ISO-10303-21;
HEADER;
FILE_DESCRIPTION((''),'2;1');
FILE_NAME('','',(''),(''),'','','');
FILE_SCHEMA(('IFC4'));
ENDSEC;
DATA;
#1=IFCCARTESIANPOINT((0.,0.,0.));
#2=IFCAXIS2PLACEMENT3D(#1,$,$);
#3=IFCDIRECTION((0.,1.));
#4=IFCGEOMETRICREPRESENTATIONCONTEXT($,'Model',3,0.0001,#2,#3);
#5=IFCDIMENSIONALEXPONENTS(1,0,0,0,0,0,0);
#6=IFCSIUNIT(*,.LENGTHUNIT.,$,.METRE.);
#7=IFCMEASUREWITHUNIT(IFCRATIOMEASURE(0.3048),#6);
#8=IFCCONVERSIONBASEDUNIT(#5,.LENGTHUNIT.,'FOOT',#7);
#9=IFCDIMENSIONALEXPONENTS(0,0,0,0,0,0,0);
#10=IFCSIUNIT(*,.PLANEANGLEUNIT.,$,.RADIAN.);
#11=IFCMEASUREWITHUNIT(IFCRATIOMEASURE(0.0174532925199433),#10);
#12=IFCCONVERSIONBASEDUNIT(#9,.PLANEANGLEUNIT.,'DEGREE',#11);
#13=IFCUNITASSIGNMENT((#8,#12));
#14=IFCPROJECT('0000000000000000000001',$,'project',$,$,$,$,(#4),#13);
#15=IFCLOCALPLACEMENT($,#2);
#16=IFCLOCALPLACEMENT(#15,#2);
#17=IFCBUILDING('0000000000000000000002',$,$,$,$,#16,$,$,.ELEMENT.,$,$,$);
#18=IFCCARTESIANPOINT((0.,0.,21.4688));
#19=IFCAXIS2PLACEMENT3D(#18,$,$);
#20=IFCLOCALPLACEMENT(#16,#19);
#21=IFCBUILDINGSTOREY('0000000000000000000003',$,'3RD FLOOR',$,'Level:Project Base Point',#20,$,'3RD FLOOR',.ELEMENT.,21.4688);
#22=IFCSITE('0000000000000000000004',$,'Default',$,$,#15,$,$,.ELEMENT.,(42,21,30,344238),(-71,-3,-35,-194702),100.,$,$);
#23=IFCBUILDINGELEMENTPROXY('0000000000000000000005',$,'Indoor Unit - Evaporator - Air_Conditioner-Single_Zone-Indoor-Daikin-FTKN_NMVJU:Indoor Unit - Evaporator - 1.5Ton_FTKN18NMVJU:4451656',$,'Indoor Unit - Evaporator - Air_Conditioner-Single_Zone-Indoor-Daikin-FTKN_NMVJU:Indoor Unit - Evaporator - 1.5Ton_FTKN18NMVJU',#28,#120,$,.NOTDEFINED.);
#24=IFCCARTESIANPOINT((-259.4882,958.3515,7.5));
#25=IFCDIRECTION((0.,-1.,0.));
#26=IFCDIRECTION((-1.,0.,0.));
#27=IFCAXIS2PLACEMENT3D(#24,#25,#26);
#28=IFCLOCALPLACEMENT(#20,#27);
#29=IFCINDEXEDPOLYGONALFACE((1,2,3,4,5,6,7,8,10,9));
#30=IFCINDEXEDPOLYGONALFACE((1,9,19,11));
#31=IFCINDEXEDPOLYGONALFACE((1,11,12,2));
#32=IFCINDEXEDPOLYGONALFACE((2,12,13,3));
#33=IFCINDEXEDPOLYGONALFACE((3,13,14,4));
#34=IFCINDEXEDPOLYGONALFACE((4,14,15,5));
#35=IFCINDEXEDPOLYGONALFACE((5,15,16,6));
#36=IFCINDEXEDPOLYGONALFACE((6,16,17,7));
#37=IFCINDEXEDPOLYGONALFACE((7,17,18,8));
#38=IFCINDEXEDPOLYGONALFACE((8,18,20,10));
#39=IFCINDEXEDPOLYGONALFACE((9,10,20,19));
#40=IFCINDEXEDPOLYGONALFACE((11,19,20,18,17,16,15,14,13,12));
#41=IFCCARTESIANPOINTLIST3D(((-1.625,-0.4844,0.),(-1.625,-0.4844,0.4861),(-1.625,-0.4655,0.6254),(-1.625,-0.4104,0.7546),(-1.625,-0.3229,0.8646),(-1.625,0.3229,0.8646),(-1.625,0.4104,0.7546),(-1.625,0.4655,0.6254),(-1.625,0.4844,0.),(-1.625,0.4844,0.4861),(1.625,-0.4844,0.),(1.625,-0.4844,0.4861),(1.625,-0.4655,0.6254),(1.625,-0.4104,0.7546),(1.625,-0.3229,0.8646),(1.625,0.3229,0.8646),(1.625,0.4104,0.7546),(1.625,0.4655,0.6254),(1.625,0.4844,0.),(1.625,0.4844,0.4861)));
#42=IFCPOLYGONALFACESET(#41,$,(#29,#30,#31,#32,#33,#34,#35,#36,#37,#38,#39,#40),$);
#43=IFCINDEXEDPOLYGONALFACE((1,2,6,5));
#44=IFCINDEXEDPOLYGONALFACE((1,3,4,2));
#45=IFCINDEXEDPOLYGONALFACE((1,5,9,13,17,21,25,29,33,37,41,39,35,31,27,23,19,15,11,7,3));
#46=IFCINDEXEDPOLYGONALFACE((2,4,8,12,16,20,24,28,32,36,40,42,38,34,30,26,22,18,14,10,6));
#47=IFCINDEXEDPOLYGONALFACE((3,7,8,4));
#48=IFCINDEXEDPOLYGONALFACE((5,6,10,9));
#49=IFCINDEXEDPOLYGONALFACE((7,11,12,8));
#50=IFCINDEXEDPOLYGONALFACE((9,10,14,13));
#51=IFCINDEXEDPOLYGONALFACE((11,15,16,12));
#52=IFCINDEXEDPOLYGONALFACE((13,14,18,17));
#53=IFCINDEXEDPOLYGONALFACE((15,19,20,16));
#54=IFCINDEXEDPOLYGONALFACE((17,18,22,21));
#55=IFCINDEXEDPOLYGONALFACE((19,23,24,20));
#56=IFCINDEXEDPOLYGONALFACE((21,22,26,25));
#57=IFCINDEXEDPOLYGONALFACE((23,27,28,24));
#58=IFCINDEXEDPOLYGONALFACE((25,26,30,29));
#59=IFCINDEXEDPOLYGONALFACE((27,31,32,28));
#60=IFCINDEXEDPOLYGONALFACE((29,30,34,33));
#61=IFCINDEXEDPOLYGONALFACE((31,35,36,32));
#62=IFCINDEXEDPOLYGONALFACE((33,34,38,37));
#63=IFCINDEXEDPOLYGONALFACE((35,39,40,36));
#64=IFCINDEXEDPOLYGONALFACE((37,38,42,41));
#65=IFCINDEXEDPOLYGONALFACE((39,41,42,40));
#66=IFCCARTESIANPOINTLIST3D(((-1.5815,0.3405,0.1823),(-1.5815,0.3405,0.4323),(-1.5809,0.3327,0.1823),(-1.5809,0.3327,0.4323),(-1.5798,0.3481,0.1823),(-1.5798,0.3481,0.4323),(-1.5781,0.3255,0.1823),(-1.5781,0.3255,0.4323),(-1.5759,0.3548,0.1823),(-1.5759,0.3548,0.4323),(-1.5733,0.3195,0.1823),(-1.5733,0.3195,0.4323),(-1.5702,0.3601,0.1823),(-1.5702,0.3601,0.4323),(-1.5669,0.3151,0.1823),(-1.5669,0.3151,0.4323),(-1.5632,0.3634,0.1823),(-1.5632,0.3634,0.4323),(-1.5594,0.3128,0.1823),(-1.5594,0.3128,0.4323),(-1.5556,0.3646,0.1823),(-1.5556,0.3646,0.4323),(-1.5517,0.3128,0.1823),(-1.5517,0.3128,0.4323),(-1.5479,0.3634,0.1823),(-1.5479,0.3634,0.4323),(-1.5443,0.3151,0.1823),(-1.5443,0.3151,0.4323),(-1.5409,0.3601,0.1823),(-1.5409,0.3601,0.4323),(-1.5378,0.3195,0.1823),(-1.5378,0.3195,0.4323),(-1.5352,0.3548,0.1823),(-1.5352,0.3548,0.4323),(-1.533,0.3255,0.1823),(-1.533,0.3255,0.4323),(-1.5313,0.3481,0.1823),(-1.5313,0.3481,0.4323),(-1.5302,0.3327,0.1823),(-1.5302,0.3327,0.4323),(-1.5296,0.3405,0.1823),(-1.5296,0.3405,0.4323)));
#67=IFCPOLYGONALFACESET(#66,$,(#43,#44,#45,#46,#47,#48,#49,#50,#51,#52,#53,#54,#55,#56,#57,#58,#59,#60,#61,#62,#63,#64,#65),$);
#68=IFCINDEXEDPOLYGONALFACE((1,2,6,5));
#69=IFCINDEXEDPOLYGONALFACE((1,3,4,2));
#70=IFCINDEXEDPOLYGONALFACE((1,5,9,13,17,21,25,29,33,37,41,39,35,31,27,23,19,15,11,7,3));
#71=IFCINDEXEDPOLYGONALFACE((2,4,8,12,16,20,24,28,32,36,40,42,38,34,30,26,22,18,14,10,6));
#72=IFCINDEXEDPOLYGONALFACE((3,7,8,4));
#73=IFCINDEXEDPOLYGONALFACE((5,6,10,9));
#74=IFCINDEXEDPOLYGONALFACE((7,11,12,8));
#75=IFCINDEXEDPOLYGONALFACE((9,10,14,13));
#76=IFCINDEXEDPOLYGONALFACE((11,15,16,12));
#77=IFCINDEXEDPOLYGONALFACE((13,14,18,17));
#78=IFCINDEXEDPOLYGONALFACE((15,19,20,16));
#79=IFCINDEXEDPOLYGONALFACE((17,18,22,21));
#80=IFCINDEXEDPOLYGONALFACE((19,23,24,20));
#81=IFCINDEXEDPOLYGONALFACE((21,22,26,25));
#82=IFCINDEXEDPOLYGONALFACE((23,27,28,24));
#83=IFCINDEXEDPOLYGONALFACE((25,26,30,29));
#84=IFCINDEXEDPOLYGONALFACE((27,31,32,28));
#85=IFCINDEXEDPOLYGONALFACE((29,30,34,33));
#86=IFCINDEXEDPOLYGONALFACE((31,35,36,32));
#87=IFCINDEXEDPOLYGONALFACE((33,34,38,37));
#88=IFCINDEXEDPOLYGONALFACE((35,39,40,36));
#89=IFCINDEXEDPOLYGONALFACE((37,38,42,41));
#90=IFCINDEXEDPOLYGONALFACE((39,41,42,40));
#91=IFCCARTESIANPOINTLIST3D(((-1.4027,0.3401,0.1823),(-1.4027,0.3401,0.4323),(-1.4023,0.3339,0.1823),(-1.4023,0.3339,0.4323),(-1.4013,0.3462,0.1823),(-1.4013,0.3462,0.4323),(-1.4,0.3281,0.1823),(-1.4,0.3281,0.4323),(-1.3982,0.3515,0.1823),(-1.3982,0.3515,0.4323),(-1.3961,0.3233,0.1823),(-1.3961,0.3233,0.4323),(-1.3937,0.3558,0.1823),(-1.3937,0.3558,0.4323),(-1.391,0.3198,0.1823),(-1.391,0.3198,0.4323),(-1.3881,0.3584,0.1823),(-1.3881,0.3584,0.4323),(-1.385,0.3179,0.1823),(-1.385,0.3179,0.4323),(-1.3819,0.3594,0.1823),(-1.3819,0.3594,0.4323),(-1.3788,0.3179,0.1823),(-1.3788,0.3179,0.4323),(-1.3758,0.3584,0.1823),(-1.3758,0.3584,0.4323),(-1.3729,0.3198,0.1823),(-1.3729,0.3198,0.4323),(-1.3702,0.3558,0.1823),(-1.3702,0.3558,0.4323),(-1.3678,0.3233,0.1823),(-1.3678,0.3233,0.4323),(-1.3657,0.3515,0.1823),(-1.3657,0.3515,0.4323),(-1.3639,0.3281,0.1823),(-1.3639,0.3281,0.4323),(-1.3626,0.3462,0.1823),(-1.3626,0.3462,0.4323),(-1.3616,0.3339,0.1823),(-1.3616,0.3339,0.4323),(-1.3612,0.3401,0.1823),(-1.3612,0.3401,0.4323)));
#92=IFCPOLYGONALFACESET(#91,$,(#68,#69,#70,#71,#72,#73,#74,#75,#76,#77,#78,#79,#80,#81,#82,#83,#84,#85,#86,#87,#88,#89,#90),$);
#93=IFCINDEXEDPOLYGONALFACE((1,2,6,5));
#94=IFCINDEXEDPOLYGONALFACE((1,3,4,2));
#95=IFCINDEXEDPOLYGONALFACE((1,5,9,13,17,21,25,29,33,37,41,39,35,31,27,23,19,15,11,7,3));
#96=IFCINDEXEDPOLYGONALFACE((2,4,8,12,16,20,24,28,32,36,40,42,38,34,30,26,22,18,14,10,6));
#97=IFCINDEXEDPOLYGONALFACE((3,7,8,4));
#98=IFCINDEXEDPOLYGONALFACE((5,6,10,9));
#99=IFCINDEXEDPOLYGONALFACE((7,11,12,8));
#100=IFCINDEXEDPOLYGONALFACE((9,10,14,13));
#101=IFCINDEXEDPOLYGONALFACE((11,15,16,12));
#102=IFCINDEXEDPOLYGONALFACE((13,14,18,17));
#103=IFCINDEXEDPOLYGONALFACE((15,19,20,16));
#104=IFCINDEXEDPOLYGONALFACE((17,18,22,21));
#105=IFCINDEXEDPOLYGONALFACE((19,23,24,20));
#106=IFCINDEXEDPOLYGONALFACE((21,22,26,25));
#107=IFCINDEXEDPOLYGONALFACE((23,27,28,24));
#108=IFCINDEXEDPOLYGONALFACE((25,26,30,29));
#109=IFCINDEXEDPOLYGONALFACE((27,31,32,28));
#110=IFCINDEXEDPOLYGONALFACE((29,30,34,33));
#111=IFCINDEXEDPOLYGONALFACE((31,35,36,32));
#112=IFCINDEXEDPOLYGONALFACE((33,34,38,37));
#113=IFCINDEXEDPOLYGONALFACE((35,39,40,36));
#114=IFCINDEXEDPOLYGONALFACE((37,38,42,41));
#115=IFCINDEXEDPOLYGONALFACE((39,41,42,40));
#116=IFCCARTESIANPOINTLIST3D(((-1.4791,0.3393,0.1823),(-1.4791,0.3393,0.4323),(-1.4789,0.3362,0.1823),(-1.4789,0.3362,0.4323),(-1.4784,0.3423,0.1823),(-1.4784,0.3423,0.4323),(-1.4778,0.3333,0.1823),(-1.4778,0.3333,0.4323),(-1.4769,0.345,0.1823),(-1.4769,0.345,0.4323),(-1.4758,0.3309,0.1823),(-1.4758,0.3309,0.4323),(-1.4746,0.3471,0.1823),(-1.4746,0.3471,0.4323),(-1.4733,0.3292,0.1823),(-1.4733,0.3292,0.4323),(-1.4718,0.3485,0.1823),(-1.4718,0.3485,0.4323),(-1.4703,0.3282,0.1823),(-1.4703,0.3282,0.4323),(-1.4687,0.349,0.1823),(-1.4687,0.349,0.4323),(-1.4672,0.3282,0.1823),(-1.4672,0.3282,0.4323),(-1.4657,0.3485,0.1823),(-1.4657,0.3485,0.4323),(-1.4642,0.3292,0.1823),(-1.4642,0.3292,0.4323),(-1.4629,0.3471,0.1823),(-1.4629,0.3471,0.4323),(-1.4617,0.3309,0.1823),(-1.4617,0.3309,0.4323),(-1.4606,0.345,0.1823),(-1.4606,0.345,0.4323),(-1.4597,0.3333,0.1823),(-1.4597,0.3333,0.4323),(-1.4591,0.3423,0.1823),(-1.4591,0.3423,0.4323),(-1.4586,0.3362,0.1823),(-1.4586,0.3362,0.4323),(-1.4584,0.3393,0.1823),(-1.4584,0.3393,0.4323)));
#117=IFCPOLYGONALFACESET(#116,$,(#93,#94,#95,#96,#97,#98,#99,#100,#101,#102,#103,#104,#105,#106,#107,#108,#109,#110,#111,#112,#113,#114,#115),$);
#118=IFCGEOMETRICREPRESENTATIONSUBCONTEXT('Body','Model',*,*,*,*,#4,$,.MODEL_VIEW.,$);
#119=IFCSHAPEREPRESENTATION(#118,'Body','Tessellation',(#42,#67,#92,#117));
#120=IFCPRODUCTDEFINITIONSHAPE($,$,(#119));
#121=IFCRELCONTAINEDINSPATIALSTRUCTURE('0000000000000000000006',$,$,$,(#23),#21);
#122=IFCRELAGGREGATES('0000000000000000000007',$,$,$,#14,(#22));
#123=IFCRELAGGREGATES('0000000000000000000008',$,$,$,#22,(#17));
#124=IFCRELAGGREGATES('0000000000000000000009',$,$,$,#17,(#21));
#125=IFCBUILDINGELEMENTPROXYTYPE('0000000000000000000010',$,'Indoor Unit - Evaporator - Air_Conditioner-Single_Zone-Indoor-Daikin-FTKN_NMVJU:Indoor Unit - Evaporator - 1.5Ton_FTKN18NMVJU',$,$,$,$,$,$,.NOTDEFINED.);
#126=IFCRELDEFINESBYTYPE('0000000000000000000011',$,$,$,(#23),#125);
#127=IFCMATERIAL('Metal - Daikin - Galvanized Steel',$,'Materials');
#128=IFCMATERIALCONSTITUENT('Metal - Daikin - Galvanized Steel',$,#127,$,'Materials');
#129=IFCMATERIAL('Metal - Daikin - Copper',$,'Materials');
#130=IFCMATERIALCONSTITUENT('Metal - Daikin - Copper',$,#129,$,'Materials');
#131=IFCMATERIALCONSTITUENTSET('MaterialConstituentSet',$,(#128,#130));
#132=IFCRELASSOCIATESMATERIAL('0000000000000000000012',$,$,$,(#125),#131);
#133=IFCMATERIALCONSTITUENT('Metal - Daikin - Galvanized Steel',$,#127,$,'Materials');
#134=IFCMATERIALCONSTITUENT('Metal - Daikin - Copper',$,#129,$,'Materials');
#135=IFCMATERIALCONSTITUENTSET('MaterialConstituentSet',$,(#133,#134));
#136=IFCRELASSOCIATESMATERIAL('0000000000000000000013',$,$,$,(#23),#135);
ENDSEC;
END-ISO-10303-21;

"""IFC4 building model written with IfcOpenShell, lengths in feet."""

from ifc_helpers import new_model, entity, si_unit, converted_unit, direction, frame, frame_2d, origin, origin_2d_with_axis, place, context, subcontext, project, spatial, polyline, circle_curve, parameter, trimmed, segment, composite_curve, circle, outline, extrude, source, transform, mapped, material, constituent, constituent_set, type_object, type_shapes, element, save


model = new_model("IFC4")

# Units and contexts
model_context = context("Model", 3, precision=0.0001, world=origin(), true_north=direction((0.0, 1.0)))
body_context = subcontext(model_context, "Body", "Model", "MODEL_VIEW")
ifc_project = project(units=[converted_unit("LENGTHUNIT", "FOOT", entity("IfcRatioMeasure", 0.3048), si_unit("LENGTHUNIT", "METRE"), dimensions=[1, 0, 0, 0, 0, 0, 0]), converted_unit("PLANEANGLEUNIT", "DEGREE", entity("IfcRatioMeasure", 0.0174532925199433), si_unit("PLANEANGLEUNIT", "RADIAN"), dimensions=[0, 0, 0, 0, 0, 0, 0])], contexts=[model_context])

# Site, building, storey
site_placement = place(None, origin())
site = spatial("IfcSite", under=ifc_project, at=site_placement, Name="Default", CompositionType="ELEMENT", RefLatitude=(42, 21, 30, 344238), RefLongitude=(-71, -3, -35, -194702), RefElevation=100.0)
building_placement = place(site_placement, origin())
building = spatial("IfcBuilding", under=site, at=building_placement, CompositionType="ELEMENT")
storey_placement = place(building_placement, frame((0.0, 0.0, 21.4688)))
storey = spatial("IfcBuildingStorey", under=building, at=storey_placement, Name="3RD FLOOR", ObjectType="Level:Project Base Point", LongName="3RD FLOOR", CompositionType="ELEMENT", Elevation=21.4688)

# Building element proxy
ifc_material_1 = material(Name="Metal - Daikin - Galvanized Steel", Category="Materials")
ifc_constituent_1 = constituent(ifc_material_1, Name="Metal - Daikin - Galvanized Steel", Category="Materials")
ifc_material_2 = material(Name="Metal - Daikin - Copper", Category="Materials")
ifc_constituent_2 = constituent(ifc_material_2, Name="Metal - Daikin - Copper", Category="Materials")
ifc_constituent_set_1 = constituent_set(constituents=[ifc_constituent_1, ifc_constituent_2], Name="MaterialConstituentSet")
ifc_constituent_3 = constituent(ifc_material_1, Name="Metal - Daikin - Galvanized Steel", Category="Materials")
ifc_constituent_4 = constituent(ifc_material_2, Name="Metal - Daikin - Copper", Category="Materials")
ifc_constituent_set_2 = constituent_set(constituents=[ifc_constituent_3, ifc_constituent_4], Name="MaterialConstituentSet")
building_element_proxy_type_1 = type_object("IfcBuildingElementProxyType", Name="Indoor Unit - Evaporator - Air_Conditioner-Single_Zone-Indoor-Daikin-FTKN_NMVJU:Indoor Unit - Evaporator - 1.5Ton_FTKN18NMVJU", PredefinedType="NOTDEFINED", material=ifc_constituent_set_2)
shared_shape_1 = source(origin(), body_context, "Body", "SweptSolid", [
    extrude(outline(composite_curve([segment(polyline([(-0.0359, -0.4844), (0.4502, -0.4844)]), True, "CONTINUOUS"), segment(polyline([(0.4502, -0.4844), (0.4502, 0.4844)]), True, "CONTINUOUS"), segment(polyline([(0.4502, 0.4844), (-0.0359, 0.4844)]), True, "CONTINUOUS"), segment(trimmed(circle_curve(frame_2d((-0.0359, -0.0399), x_axis=(0.0, 1.0)), 0.5243), [parameter(0.0)], [parameter(46.206724)], True, "PARAMETER"), True, "CONTINUOUS"), segment(polyline([(-0.4144, 0.3229), (-0.4144, -0.3229)]), True, "CONTINUOUS"), segment(trimmed(circle_curve(frame_2d((-0.0359, 0.0399), x_axis=(0.0, 1.0)), 0.5243), [parameter(133.793276)], [parameter(180.0)], True, "PARAMETER"), True, "CONTINUOUS")], self_intersect=False)), frame((-1.625, 0.0, 0.4502), z_axis=(1.0, 0.0, 0.0), x_axis=(0.0, 0.0, -1.0)), (0.0, 0.0, 1.0), 3.25),
    extrude(circle(Radius=0.026, at=frame_2d((0.0, 0.0), x_axis=(1.0, 0.0))), frame((-1.5556, 0.3385, 0.1823), z_axis=(0.0, 0.0, 1.0), x_axis=(0.0, 1.0, 0.0)), (0.0, 0.0, 1.0), 0.25),
    extrude(circle(Radius=0.0208, at=origin_2d_with_axis()), frame((-1.3819, 0.3385, 0.1823), z_axis=(0.0, 0.0, 1.0), x_axis=(0.0, 1.0, 0.0)), (0.0, 0.0, 1.0), 0.25),
    extrude(circle(Radius=0.0104, at=origin_2d_with_axis()), frame((-1.4687, 0.3385, 0.1823), z_axis=(0.0, 0.0, 1.0), x_axis=(0.0, 1.0, 0.0)), (0.0, 0.0, 1.0), 0.25),
])
type_shapes(building_element_proxy_type_1, [shared_shape_1])
proxy_1_placement = place(storey_placement, frame((-259.4882, 958.3515, 7.5), z_axis=(0.0, -1.0, 0.0), x_axis=(-1.0, 0.0, 0.0)))
element("IfcBuildingElementProxy", 1, at=proxy_1_placement, inside=storey, type_object=building_element_proxy_type_1, material=ifc_constituent_set_1, Name="Indoor Unit - Evaporator - Air_Conditioner-Single_Zone-Indoor-Daikin-FTKN_NMVJU:Indoor Unit - Evaporator - 1.5Ton_FTKN18NMVJU:4451656", ObjectType="Indoor Unit - Evaporator - Air_Conditioner-Single_Zone-Indoor-Daikin-FTKN_NMVJU:Indoor Unit - Evaporator - 1.5Ton_FTKN18NMVJU", PredefinedType="NOTDEFINED", context=body_context, shape_type="MappedRepresentation", body=[
    mapped(shared_shape_1, transform((0.0, 0.0, 0.0), scale=1.0)),
])

save(model, "model.ifc")
